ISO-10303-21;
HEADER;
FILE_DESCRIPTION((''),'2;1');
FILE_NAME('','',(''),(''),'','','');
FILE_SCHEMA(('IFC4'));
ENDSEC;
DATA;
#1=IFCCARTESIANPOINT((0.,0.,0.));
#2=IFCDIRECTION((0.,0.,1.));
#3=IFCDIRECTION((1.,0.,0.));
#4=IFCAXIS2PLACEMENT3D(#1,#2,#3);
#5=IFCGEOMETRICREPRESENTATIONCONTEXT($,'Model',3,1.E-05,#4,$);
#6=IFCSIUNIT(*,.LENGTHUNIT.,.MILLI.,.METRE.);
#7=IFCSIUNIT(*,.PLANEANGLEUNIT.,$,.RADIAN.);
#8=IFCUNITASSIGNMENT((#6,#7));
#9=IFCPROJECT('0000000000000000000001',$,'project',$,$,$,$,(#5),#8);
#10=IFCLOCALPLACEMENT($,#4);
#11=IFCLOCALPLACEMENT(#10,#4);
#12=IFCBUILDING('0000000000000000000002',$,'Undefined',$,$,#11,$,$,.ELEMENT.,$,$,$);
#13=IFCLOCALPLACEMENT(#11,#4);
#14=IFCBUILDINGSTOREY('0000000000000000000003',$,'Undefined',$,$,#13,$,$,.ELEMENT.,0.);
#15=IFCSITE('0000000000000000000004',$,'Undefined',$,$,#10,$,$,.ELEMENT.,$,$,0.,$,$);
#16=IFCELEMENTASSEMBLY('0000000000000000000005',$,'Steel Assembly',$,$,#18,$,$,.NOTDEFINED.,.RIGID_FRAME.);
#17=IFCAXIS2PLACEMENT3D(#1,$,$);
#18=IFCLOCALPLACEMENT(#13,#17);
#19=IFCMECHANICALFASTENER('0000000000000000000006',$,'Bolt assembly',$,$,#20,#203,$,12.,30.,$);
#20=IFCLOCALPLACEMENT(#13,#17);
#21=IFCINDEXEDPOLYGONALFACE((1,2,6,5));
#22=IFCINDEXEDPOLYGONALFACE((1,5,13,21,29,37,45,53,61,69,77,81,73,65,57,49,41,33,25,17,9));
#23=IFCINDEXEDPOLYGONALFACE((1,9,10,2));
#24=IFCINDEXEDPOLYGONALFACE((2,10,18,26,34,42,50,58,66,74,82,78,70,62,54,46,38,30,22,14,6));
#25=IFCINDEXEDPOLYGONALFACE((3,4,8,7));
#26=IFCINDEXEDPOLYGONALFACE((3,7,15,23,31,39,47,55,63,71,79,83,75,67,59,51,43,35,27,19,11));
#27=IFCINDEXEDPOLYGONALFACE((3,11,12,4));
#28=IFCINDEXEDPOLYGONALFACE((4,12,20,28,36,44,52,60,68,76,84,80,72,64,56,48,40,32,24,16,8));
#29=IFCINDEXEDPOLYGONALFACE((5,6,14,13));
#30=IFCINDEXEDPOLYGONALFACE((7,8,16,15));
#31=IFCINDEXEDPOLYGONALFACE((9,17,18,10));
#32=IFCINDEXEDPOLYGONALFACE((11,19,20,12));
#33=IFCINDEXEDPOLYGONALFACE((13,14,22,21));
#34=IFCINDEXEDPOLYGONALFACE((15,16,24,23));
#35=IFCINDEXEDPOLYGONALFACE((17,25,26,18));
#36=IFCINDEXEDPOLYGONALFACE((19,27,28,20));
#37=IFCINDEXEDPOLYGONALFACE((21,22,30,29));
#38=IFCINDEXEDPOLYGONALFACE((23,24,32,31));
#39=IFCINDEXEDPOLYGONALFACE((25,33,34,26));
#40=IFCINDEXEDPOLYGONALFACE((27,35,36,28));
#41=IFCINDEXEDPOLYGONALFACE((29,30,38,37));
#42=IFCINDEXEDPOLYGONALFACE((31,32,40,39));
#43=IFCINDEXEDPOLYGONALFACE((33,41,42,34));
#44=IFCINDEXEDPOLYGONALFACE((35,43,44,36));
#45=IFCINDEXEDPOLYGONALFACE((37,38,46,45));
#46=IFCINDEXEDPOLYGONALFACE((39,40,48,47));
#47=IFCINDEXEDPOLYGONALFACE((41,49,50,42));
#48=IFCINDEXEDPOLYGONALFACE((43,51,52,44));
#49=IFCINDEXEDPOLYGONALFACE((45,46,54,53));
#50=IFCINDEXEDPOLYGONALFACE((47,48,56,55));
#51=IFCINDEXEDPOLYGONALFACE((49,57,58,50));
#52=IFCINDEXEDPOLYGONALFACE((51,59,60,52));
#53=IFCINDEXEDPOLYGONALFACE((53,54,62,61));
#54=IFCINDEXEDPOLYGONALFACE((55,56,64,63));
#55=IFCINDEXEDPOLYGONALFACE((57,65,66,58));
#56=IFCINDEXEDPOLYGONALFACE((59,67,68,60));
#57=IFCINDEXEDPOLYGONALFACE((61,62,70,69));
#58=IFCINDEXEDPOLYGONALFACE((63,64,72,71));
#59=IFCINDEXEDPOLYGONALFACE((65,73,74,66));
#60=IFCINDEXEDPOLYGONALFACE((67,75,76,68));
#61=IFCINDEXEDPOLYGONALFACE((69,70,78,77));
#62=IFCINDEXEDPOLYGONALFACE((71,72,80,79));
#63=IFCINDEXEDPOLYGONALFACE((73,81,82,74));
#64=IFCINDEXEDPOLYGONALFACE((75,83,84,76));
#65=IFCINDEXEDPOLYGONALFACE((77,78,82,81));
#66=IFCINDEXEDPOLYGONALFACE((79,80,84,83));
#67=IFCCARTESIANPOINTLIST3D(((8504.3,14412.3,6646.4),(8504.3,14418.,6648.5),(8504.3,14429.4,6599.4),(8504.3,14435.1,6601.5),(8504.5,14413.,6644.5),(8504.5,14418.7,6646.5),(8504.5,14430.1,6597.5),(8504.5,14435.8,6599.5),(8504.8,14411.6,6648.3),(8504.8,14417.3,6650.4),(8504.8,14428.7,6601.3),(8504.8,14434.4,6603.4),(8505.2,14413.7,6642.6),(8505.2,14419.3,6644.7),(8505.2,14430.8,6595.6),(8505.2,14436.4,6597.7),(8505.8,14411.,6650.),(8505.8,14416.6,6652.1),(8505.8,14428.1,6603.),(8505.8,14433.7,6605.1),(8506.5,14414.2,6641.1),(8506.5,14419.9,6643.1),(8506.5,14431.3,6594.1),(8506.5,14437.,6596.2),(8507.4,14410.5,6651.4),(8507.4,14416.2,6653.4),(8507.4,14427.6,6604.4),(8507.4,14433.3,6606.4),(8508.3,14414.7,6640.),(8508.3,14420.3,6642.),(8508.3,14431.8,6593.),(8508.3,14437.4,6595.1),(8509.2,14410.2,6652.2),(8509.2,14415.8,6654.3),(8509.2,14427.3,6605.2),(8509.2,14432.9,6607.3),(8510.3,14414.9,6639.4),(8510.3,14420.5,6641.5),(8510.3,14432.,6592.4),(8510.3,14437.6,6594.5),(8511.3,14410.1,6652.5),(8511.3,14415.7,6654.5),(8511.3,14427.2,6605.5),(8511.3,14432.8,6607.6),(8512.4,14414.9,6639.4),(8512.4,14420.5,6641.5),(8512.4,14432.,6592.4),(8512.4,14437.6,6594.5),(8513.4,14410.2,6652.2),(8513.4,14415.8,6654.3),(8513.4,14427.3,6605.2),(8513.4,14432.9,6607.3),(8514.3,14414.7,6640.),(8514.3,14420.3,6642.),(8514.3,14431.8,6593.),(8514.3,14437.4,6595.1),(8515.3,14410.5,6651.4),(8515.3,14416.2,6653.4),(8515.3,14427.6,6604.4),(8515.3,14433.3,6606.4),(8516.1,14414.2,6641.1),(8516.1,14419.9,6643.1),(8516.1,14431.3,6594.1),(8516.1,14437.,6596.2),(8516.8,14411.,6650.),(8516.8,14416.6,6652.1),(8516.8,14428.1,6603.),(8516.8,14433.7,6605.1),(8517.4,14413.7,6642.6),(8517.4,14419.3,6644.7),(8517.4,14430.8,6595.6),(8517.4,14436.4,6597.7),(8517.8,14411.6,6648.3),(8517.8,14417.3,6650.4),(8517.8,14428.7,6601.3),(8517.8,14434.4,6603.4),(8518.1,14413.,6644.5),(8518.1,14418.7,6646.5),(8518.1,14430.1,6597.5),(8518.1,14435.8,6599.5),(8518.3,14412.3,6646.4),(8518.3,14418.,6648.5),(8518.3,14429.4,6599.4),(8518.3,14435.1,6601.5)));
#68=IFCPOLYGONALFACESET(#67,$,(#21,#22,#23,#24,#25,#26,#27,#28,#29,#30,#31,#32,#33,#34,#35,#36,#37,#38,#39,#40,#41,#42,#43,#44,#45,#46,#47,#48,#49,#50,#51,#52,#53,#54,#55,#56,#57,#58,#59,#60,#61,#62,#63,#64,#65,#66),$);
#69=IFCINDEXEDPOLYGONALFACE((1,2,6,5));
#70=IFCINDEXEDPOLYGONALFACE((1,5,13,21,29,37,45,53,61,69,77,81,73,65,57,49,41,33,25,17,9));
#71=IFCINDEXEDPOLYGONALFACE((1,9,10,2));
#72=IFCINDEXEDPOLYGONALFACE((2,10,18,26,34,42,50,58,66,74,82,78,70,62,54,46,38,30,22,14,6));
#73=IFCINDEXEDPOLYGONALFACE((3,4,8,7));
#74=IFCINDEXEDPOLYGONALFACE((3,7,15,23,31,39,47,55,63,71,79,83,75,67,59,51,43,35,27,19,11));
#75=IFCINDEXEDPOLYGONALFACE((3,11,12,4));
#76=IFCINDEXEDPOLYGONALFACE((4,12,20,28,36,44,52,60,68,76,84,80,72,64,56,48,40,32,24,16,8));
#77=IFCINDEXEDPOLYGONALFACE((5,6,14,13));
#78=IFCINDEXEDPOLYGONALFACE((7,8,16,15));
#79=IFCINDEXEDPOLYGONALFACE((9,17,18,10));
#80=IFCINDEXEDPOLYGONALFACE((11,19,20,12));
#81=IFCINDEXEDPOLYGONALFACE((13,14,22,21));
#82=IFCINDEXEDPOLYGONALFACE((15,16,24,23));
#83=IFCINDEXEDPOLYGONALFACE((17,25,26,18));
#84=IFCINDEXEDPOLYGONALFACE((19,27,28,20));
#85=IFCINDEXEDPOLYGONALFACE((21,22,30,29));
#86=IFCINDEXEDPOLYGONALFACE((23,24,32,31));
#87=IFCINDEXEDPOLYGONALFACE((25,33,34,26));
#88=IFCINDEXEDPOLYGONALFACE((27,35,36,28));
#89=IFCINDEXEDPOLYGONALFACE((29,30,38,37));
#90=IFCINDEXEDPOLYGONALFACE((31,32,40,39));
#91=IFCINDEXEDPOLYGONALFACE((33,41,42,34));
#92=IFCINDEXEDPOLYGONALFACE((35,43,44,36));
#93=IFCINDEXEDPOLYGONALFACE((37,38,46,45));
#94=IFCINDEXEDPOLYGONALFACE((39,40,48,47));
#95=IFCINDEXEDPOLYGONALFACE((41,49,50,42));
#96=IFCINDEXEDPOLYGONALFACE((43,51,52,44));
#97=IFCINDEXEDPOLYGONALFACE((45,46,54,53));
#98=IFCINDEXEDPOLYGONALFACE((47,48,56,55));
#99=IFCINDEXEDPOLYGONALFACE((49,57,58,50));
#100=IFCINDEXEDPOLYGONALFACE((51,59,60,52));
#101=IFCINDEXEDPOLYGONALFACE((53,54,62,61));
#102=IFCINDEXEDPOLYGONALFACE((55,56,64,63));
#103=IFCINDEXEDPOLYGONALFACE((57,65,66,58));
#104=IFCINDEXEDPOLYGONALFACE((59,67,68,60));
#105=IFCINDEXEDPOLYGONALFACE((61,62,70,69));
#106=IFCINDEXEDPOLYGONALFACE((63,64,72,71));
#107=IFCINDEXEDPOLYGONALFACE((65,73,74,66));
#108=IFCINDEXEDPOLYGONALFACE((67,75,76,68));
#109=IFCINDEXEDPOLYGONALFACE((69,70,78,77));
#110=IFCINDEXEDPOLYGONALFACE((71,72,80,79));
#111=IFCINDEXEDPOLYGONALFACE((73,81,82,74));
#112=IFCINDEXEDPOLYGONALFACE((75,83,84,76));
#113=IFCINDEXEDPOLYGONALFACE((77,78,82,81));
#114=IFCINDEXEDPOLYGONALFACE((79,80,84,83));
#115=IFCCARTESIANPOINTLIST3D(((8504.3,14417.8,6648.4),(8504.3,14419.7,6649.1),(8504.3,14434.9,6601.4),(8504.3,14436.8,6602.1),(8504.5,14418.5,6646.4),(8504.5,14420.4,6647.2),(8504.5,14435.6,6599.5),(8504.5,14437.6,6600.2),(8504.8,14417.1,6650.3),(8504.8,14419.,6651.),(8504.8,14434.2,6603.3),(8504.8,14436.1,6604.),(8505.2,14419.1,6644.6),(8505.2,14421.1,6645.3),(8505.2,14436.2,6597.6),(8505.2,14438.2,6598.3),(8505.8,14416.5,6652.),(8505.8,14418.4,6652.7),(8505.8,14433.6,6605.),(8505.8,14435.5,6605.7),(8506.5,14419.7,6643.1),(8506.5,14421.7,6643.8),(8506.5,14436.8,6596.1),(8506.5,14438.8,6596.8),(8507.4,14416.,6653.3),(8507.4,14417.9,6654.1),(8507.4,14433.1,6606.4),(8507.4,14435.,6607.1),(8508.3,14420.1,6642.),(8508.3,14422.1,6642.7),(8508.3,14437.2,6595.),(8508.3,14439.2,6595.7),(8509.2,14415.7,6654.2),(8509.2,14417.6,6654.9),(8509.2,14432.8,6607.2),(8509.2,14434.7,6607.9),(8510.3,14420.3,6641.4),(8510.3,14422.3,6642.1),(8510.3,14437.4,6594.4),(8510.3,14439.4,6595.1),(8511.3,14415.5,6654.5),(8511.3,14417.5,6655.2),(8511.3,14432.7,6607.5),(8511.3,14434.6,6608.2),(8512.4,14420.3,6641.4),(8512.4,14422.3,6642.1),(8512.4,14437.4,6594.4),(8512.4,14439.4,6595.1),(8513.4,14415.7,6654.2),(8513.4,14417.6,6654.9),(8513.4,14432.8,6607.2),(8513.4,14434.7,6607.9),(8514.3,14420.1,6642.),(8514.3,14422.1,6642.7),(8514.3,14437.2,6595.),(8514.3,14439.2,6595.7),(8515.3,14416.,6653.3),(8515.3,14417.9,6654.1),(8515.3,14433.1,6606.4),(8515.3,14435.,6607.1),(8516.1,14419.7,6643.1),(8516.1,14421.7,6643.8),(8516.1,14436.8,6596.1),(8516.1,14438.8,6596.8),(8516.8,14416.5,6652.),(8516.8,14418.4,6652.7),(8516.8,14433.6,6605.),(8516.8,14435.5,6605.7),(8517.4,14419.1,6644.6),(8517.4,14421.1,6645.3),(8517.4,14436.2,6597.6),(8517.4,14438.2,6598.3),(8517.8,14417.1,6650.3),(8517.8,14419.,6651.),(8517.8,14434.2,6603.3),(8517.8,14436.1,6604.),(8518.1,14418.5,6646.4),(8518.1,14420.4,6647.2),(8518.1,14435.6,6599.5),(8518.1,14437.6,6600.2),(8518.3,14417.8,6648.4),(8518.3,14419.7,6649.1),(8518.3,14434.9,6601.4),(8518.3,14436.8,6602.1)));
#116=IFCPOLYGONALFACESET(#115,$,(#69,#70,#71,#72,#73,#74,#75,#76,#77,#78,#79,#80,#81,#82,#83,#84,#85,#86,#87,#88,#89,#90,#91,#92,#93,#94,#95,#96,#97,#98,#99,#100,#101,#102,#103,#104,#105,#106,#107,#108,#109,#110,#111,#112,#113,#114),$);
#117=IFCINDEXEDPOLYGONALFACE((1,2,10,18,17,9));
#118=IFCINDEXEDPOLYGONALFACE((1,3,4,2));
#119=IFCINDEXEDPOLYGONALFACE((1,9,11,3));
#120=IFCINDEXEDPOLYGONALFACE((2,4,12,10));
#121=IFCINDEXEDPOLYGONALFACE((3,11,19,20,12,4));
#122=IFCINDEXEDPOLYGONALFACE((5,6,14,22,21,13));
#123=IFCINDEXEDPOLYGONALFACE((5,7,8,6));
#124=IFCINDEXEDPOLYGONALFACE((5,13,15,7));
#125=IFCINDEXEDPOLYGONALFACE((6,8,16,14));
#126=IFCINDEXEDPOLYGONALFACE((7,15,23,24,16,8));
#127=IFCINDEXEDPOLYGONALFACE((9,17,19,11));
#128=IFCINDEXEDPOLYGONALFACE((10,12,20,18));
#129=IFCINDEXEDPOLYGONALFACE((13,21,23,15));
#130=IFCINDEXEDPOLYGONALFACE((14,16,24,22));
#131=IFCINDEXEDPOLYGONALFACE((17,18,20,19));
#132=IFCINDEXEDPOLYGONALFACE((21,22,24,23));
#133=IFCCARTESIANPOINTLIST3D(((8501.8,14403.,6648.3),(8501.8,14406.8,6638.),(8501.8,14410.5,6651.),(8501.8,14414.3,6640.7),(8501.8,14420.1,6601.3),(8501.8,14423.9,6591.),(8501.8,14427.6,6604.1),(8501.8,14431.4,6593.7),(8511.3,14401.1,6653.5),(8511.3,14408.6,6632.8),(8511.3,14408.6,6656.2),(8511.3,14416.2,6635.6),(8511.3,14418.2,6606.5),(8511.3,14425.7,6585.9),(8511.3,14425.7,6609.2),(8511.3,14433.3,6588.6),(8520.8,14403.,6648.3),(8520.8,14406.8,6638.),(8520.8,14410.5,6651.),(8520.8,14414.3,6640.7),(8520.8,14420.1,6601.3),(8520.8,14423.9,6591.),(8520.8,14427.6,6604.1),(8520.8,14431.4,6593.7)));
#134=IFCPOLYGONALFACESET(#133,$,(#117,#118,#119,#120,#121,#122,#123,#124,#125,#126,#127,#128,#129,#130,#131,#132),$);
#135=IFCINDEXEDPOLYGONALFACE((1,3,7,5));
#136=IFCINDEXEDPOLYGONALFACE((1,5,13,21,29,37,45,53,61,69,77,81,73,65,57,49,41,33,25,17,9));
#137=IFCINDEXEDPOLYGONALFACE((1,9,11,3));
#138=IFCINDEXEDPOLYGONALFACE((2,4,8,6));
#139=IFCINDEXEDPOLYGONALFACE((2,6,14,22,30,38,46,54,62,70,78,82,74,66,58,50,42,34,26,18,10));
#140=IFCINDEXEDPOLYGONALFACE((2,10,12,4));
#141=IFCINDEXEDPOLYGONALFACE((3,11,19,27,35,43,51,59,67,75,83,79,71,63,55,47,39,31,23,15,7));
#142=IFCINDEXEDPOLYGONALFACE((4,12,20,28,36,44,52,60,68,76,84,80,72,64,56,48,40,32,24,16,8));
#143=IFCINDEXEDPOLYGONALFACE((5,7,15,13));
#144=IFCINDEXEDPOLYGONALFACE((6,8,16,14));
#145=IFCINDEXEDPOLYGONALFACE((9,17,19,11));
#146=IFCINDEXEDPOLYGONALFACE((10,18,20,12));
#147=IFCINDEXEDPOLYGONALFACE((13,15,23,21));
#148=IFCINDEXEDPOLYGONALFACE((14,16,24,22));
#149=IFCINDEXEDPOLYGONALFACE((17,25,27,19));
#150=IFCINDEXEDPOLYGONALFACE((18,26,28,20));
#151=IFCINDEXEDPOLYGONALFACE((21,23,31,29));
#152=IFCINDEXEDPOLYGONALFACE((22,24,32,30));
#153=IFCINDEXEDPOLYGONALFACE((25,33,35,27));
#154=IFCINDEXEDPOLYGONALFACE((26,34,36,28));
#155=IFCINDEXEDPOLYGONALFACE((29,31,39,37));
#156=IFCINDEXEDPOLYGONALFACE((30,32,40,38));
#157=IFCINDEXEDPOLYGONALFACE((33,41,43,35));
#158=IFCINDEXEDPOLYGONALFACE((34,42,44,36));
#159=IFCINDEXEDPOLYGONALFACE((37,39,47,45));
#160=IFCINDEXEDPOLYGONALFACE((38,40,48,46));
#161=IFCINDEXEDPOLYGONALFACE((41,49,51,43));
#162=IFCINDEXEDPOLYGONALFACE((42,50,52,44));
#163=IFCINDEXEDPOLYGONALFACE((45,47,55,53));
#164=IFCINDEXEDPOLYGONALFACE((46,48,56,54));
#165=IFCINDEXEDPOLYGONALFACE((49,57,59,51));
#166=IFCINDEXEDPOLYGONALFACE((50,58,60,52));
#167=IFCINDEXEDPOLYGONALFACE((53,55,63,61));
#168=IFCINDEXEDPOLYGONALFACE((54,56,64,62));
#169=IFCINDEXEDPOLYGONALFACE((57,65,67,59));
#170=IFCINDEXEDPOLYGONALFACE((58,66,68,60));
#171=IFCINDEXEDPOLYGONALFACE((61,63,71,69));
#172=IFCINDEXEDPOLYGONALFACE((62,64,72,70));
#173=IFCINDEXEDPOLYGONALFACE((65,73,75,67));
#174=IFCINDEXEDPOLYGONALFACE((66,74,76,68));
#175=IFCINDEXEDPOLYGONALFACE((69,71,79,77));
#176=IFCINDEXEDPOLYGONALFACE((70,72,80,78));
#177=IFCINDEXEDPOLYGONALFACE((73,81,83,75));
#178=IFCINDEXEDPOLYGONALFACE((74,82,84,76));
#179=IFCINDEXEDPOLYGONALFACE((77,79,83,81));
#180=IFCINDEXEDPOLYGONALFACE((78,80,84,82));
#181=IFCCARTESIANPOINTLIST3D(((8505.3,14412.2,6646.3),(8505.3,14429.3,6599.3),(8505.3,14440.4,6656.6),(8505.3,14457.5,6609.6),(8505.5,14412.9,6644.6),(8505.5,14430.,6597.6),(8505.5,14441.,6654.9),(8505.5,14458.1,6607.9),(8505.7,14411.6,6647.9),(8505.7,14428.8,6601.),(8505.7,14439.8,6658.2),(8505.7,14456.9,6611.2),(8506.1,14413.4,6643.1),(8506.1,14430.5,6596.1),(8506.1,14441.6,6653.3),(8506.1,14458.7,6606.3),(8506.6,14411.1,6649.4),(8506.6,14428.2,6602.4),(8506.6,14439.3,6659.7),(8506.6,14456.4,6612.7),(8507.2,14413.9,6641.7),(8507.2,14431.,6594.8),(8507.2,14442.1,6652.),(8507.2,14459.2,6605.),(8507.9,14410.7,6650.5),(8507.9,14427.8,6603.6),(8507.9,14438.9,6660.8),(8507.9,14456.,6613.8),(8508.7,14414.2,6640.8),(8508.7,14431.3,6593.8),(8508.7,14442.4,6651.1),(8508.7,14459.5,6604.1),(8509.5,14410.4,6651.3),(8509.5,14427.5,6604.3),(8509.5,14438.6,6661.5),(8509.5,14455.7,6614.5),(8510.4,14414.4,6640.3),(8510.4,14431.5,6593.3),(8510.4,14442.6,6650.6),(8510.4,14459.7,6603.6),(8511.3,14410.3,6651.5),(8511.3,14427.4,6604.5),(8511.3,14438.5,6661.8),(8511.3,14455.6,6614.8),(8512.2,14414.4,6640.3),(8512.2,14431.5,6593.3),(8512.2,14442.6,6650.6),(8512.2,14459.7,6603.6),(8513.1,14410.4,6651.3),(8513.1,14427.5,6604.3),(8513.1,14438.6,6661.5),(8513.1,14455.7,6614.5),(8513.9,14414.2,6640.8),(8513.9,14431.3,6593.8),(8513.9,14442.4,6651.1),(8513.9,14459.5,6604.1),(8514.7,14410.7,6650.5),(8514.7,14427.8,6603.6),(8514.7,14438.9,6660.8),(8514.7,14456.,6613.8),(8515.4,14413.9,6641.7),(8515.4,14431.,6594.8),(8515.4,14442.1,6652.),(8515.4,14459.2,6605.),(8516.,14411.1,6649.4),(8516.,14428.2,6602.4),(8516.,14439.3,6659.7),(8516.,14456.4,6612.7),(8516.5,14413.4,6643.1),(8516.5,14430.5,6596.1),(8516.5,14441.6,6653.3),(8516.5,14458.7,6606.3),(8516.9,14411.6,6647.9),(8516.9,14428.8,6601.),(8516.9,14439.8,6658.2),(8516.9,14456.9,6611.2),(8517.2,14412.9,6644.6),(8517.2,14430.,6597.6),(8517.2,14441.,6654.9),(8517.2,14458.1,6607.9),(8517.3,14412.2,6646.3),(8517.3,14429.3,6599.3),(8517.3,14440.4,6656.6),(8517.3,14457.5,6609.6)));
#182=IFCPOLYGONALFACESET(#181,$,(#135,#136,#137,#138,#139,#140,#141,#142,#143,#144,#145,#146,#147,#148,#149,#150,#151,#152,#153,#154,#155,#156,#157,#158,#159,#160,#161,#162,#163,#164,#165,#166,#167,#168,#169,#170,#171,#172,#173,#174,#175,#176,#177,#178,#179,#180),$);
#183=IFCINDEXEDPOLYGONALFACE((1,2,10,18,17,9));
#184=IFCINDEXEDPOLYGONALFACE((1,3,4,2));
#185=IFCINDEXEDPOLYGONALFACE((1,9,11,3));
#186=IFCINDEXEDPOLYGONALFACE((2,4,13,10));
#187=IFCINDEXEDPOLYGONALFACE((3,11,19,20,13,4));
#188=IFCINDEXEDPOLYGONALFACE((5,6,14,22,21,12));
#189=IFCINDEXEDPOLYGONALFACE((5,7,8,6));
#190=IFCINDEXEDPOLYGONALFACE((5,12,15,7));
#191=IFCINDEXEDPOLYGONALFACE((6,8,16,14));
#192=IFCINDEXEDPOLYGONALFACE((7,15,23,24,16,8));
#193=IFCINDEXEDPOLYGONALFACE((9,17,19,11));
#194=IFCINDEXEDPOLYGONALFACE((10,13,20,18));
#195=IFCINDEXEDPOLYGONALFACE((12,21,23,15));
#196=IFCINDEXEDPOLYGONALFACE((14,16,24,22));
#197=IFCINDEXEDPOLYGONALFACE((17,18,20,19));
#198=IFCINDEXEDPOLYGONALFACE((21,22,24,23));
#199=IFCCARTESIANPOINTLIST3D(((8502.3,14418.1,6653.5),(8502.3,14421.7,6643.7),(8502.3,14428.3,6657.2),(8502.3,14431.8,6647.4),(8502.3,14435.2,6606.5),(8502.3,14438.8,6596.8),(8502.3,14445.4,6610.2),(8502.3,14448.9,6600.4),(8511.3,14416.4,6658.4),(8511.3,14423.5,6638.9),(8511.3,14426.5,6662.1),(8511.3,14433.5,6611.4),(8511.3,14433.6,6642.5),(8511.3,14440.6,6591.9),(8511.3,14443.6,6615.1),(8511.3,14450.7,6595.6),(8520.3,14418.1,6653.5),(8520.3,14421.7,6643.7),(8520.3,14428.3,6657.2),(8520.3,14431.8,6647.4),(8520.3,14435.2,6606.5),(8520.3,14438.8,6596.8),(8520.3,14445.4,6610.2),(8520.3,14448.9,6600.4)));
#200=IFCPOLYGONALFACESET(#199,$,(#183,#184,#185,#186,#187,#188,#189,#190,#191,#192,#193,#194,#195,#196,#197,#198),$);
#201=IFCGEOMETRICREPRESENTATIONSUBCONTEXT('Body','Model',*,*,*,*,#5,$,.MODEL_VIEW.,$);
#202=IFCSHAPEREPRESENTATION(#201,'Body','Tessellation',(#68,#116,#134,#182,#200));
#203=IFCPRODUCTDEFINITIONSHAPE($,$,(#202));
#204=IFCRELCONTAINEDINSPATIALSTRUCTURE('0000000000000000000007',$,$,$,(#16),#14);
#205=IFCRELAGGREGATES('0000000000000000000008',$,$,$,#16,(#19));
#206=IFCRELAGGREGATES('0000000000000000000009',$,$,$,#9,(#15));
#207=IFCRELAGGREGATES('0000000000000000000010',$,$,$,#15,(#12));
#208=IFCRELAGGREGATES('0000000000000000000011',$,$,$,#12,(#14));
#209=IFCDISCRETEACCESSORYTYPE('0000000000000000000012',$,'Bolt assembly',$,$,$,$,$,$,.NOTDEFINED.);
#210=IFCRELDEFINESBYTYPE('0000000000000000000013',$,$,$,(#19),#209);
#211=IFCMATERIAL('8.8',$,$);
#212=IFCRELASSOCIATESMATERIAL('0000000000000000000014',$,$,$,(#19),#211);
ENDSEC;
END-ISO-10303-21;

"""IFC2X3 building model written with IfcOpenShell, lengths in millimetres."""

from ifc_helpers import new_model, si_unit, frame, origin_with_axes, origin_2d_with_axis, place, context, subcontext, project, spatial, polyline, circle, outline, extrude, source, transform, mapped, material, type_object, element, aggregate, save


model = new_model("IFC2X3")

# Units and contexts
model_context = context("Model", 3, precision=1e-05, world=origin_with_axes())
body_context = subcontext(model_context, "Body", "Model", "MODEL_VIEW")
ifc_project = project(units=[si_unit("LENGTHUNIT", "METRE", prefix="MILLI"), si_unit("PLANEANGLEUNIT", "RADIAN")], contexts=[model_context])

# Site, building, storey
site_placement = place(None, origin_with_axes())
site = spatial("IfcSite", under=ifc_project, at=site_placement, Name="Undefined", CompositionType="ELEMENT", RefElevation=0.0)
building_placement = place(site_placement, origin_with_axes())
building = spatial("IfcBuilding", under=site, at=building_placement, Name="Undefined", CompositionType="ELEMENT")
storey_placement = place(building_placement, origin_with_axes())
storey = spatial("IfcBuildingStorey", under=building, at=storey_placement, Name="Undefined", CompositionType="ELEMENT", Elevation=0.0)

# Shared definitions
ifc_material_1 = material(Name="8.8")
discrete_accessory_type_1 = type_object("IfcDiscreteAccessoryType", Name="Bolt assembly")
shared_shape_1 = source(origin_with_axes(), body_context, "Body", "SweptSolid", [
    extrude(circle(Radius=7.0, at=origin_2d_with_axis()), frame((0.0, -5.9, 0.0), z_axis=(0.0, 1.0, 0.0), x_axis=(1.0, 0.0, 0.0)), (0.0, 0.0, 1.0), 6.0),
    extrude(circle(Radius=7.0, at=origin_2d_with_axis()), frame((0.0, -0.1, 0.0), z_axis=(0.0, 1.0, 0.0), x_axis=(1.0, 0.0, 0.0)), (0.0, 0.0, 1.0), 2.1),
    extrude(outline(polyline([(11.0, 0.0), (5.5, 9.5), (-5.5, 9.5), (-11.0, 0.0), (-5.5, -9.5), (5.5, -9.5), (11.0, 0.0)])), frame((0.0, -14.0, 0.0), z_axis=(0.0, 1.0, 0.0), x_axis=(1.0, 0.0, 0.0)), (0.0, 0.0, 1.0), 8.0),
    extrude(circle(Radius=6.0, at=origin_2d_with_axis()), frame((0.0, -6.0, 0.0), z_axis=(0.0, 1.0, 0.0), x_axis=(1.0, 0.0, 0.0)), (0.0, 0.0, 1.0), 30.0),
    extrude(outline(polyline([(10.4, 0.0), (5.2, 9.0), (-5.2, 9.0), (-10.4, 0.0), (-5.2, -9.0), (5.2, -9.0), (10.4, 0.0)])), frame((0.0, 2.0, 0.0), z_axis=(0.0, 1.0, 0.0), x_axis=(1.0, 0.0, 0.0)), (0.0, 0.0, 1.0), 10.8),
])

# Element assembly, mechanical fastener
assembly_1_placement = place(storey_placement, origin_with_axes())
assembly_1 = element("IfcElementAssembly", 1, at=assembly_1_placement, inside=storey, Name="Steel Assembly", AssemblyPlace="NOTDEFINED", PredefinedType="RIGID_FRAME")
mechanical_fastener_1_placement = place(assembly_1_placement, frame((8511.3, 14435.1, 6601.0), z_axis=(-1.0, 0.0, 0.0), x_axis=(0.0, -0.34202, 0.939693)))
mechanical_fastener_1 = element("IfcMechanicalFastener", 2, at=mechanical_fastener_1_placement, type_object=discrete_accessory_type_1, material=ifc_material_1, Name="Bolt assembly", NominalDiameter=12.0, NominalLength=30.0, context=body_context, shape_type="MappedRepresentation", body=[
    mapped(shared_shape_1, transform((0.0, 0.0, 0.0))),
    mapped(shared_shape_1, transform((50.0, 0.0, 0.0))),
])

aggregate(assembly_1, [mechanical_fastener_1])

save(model, "model.ifc")
